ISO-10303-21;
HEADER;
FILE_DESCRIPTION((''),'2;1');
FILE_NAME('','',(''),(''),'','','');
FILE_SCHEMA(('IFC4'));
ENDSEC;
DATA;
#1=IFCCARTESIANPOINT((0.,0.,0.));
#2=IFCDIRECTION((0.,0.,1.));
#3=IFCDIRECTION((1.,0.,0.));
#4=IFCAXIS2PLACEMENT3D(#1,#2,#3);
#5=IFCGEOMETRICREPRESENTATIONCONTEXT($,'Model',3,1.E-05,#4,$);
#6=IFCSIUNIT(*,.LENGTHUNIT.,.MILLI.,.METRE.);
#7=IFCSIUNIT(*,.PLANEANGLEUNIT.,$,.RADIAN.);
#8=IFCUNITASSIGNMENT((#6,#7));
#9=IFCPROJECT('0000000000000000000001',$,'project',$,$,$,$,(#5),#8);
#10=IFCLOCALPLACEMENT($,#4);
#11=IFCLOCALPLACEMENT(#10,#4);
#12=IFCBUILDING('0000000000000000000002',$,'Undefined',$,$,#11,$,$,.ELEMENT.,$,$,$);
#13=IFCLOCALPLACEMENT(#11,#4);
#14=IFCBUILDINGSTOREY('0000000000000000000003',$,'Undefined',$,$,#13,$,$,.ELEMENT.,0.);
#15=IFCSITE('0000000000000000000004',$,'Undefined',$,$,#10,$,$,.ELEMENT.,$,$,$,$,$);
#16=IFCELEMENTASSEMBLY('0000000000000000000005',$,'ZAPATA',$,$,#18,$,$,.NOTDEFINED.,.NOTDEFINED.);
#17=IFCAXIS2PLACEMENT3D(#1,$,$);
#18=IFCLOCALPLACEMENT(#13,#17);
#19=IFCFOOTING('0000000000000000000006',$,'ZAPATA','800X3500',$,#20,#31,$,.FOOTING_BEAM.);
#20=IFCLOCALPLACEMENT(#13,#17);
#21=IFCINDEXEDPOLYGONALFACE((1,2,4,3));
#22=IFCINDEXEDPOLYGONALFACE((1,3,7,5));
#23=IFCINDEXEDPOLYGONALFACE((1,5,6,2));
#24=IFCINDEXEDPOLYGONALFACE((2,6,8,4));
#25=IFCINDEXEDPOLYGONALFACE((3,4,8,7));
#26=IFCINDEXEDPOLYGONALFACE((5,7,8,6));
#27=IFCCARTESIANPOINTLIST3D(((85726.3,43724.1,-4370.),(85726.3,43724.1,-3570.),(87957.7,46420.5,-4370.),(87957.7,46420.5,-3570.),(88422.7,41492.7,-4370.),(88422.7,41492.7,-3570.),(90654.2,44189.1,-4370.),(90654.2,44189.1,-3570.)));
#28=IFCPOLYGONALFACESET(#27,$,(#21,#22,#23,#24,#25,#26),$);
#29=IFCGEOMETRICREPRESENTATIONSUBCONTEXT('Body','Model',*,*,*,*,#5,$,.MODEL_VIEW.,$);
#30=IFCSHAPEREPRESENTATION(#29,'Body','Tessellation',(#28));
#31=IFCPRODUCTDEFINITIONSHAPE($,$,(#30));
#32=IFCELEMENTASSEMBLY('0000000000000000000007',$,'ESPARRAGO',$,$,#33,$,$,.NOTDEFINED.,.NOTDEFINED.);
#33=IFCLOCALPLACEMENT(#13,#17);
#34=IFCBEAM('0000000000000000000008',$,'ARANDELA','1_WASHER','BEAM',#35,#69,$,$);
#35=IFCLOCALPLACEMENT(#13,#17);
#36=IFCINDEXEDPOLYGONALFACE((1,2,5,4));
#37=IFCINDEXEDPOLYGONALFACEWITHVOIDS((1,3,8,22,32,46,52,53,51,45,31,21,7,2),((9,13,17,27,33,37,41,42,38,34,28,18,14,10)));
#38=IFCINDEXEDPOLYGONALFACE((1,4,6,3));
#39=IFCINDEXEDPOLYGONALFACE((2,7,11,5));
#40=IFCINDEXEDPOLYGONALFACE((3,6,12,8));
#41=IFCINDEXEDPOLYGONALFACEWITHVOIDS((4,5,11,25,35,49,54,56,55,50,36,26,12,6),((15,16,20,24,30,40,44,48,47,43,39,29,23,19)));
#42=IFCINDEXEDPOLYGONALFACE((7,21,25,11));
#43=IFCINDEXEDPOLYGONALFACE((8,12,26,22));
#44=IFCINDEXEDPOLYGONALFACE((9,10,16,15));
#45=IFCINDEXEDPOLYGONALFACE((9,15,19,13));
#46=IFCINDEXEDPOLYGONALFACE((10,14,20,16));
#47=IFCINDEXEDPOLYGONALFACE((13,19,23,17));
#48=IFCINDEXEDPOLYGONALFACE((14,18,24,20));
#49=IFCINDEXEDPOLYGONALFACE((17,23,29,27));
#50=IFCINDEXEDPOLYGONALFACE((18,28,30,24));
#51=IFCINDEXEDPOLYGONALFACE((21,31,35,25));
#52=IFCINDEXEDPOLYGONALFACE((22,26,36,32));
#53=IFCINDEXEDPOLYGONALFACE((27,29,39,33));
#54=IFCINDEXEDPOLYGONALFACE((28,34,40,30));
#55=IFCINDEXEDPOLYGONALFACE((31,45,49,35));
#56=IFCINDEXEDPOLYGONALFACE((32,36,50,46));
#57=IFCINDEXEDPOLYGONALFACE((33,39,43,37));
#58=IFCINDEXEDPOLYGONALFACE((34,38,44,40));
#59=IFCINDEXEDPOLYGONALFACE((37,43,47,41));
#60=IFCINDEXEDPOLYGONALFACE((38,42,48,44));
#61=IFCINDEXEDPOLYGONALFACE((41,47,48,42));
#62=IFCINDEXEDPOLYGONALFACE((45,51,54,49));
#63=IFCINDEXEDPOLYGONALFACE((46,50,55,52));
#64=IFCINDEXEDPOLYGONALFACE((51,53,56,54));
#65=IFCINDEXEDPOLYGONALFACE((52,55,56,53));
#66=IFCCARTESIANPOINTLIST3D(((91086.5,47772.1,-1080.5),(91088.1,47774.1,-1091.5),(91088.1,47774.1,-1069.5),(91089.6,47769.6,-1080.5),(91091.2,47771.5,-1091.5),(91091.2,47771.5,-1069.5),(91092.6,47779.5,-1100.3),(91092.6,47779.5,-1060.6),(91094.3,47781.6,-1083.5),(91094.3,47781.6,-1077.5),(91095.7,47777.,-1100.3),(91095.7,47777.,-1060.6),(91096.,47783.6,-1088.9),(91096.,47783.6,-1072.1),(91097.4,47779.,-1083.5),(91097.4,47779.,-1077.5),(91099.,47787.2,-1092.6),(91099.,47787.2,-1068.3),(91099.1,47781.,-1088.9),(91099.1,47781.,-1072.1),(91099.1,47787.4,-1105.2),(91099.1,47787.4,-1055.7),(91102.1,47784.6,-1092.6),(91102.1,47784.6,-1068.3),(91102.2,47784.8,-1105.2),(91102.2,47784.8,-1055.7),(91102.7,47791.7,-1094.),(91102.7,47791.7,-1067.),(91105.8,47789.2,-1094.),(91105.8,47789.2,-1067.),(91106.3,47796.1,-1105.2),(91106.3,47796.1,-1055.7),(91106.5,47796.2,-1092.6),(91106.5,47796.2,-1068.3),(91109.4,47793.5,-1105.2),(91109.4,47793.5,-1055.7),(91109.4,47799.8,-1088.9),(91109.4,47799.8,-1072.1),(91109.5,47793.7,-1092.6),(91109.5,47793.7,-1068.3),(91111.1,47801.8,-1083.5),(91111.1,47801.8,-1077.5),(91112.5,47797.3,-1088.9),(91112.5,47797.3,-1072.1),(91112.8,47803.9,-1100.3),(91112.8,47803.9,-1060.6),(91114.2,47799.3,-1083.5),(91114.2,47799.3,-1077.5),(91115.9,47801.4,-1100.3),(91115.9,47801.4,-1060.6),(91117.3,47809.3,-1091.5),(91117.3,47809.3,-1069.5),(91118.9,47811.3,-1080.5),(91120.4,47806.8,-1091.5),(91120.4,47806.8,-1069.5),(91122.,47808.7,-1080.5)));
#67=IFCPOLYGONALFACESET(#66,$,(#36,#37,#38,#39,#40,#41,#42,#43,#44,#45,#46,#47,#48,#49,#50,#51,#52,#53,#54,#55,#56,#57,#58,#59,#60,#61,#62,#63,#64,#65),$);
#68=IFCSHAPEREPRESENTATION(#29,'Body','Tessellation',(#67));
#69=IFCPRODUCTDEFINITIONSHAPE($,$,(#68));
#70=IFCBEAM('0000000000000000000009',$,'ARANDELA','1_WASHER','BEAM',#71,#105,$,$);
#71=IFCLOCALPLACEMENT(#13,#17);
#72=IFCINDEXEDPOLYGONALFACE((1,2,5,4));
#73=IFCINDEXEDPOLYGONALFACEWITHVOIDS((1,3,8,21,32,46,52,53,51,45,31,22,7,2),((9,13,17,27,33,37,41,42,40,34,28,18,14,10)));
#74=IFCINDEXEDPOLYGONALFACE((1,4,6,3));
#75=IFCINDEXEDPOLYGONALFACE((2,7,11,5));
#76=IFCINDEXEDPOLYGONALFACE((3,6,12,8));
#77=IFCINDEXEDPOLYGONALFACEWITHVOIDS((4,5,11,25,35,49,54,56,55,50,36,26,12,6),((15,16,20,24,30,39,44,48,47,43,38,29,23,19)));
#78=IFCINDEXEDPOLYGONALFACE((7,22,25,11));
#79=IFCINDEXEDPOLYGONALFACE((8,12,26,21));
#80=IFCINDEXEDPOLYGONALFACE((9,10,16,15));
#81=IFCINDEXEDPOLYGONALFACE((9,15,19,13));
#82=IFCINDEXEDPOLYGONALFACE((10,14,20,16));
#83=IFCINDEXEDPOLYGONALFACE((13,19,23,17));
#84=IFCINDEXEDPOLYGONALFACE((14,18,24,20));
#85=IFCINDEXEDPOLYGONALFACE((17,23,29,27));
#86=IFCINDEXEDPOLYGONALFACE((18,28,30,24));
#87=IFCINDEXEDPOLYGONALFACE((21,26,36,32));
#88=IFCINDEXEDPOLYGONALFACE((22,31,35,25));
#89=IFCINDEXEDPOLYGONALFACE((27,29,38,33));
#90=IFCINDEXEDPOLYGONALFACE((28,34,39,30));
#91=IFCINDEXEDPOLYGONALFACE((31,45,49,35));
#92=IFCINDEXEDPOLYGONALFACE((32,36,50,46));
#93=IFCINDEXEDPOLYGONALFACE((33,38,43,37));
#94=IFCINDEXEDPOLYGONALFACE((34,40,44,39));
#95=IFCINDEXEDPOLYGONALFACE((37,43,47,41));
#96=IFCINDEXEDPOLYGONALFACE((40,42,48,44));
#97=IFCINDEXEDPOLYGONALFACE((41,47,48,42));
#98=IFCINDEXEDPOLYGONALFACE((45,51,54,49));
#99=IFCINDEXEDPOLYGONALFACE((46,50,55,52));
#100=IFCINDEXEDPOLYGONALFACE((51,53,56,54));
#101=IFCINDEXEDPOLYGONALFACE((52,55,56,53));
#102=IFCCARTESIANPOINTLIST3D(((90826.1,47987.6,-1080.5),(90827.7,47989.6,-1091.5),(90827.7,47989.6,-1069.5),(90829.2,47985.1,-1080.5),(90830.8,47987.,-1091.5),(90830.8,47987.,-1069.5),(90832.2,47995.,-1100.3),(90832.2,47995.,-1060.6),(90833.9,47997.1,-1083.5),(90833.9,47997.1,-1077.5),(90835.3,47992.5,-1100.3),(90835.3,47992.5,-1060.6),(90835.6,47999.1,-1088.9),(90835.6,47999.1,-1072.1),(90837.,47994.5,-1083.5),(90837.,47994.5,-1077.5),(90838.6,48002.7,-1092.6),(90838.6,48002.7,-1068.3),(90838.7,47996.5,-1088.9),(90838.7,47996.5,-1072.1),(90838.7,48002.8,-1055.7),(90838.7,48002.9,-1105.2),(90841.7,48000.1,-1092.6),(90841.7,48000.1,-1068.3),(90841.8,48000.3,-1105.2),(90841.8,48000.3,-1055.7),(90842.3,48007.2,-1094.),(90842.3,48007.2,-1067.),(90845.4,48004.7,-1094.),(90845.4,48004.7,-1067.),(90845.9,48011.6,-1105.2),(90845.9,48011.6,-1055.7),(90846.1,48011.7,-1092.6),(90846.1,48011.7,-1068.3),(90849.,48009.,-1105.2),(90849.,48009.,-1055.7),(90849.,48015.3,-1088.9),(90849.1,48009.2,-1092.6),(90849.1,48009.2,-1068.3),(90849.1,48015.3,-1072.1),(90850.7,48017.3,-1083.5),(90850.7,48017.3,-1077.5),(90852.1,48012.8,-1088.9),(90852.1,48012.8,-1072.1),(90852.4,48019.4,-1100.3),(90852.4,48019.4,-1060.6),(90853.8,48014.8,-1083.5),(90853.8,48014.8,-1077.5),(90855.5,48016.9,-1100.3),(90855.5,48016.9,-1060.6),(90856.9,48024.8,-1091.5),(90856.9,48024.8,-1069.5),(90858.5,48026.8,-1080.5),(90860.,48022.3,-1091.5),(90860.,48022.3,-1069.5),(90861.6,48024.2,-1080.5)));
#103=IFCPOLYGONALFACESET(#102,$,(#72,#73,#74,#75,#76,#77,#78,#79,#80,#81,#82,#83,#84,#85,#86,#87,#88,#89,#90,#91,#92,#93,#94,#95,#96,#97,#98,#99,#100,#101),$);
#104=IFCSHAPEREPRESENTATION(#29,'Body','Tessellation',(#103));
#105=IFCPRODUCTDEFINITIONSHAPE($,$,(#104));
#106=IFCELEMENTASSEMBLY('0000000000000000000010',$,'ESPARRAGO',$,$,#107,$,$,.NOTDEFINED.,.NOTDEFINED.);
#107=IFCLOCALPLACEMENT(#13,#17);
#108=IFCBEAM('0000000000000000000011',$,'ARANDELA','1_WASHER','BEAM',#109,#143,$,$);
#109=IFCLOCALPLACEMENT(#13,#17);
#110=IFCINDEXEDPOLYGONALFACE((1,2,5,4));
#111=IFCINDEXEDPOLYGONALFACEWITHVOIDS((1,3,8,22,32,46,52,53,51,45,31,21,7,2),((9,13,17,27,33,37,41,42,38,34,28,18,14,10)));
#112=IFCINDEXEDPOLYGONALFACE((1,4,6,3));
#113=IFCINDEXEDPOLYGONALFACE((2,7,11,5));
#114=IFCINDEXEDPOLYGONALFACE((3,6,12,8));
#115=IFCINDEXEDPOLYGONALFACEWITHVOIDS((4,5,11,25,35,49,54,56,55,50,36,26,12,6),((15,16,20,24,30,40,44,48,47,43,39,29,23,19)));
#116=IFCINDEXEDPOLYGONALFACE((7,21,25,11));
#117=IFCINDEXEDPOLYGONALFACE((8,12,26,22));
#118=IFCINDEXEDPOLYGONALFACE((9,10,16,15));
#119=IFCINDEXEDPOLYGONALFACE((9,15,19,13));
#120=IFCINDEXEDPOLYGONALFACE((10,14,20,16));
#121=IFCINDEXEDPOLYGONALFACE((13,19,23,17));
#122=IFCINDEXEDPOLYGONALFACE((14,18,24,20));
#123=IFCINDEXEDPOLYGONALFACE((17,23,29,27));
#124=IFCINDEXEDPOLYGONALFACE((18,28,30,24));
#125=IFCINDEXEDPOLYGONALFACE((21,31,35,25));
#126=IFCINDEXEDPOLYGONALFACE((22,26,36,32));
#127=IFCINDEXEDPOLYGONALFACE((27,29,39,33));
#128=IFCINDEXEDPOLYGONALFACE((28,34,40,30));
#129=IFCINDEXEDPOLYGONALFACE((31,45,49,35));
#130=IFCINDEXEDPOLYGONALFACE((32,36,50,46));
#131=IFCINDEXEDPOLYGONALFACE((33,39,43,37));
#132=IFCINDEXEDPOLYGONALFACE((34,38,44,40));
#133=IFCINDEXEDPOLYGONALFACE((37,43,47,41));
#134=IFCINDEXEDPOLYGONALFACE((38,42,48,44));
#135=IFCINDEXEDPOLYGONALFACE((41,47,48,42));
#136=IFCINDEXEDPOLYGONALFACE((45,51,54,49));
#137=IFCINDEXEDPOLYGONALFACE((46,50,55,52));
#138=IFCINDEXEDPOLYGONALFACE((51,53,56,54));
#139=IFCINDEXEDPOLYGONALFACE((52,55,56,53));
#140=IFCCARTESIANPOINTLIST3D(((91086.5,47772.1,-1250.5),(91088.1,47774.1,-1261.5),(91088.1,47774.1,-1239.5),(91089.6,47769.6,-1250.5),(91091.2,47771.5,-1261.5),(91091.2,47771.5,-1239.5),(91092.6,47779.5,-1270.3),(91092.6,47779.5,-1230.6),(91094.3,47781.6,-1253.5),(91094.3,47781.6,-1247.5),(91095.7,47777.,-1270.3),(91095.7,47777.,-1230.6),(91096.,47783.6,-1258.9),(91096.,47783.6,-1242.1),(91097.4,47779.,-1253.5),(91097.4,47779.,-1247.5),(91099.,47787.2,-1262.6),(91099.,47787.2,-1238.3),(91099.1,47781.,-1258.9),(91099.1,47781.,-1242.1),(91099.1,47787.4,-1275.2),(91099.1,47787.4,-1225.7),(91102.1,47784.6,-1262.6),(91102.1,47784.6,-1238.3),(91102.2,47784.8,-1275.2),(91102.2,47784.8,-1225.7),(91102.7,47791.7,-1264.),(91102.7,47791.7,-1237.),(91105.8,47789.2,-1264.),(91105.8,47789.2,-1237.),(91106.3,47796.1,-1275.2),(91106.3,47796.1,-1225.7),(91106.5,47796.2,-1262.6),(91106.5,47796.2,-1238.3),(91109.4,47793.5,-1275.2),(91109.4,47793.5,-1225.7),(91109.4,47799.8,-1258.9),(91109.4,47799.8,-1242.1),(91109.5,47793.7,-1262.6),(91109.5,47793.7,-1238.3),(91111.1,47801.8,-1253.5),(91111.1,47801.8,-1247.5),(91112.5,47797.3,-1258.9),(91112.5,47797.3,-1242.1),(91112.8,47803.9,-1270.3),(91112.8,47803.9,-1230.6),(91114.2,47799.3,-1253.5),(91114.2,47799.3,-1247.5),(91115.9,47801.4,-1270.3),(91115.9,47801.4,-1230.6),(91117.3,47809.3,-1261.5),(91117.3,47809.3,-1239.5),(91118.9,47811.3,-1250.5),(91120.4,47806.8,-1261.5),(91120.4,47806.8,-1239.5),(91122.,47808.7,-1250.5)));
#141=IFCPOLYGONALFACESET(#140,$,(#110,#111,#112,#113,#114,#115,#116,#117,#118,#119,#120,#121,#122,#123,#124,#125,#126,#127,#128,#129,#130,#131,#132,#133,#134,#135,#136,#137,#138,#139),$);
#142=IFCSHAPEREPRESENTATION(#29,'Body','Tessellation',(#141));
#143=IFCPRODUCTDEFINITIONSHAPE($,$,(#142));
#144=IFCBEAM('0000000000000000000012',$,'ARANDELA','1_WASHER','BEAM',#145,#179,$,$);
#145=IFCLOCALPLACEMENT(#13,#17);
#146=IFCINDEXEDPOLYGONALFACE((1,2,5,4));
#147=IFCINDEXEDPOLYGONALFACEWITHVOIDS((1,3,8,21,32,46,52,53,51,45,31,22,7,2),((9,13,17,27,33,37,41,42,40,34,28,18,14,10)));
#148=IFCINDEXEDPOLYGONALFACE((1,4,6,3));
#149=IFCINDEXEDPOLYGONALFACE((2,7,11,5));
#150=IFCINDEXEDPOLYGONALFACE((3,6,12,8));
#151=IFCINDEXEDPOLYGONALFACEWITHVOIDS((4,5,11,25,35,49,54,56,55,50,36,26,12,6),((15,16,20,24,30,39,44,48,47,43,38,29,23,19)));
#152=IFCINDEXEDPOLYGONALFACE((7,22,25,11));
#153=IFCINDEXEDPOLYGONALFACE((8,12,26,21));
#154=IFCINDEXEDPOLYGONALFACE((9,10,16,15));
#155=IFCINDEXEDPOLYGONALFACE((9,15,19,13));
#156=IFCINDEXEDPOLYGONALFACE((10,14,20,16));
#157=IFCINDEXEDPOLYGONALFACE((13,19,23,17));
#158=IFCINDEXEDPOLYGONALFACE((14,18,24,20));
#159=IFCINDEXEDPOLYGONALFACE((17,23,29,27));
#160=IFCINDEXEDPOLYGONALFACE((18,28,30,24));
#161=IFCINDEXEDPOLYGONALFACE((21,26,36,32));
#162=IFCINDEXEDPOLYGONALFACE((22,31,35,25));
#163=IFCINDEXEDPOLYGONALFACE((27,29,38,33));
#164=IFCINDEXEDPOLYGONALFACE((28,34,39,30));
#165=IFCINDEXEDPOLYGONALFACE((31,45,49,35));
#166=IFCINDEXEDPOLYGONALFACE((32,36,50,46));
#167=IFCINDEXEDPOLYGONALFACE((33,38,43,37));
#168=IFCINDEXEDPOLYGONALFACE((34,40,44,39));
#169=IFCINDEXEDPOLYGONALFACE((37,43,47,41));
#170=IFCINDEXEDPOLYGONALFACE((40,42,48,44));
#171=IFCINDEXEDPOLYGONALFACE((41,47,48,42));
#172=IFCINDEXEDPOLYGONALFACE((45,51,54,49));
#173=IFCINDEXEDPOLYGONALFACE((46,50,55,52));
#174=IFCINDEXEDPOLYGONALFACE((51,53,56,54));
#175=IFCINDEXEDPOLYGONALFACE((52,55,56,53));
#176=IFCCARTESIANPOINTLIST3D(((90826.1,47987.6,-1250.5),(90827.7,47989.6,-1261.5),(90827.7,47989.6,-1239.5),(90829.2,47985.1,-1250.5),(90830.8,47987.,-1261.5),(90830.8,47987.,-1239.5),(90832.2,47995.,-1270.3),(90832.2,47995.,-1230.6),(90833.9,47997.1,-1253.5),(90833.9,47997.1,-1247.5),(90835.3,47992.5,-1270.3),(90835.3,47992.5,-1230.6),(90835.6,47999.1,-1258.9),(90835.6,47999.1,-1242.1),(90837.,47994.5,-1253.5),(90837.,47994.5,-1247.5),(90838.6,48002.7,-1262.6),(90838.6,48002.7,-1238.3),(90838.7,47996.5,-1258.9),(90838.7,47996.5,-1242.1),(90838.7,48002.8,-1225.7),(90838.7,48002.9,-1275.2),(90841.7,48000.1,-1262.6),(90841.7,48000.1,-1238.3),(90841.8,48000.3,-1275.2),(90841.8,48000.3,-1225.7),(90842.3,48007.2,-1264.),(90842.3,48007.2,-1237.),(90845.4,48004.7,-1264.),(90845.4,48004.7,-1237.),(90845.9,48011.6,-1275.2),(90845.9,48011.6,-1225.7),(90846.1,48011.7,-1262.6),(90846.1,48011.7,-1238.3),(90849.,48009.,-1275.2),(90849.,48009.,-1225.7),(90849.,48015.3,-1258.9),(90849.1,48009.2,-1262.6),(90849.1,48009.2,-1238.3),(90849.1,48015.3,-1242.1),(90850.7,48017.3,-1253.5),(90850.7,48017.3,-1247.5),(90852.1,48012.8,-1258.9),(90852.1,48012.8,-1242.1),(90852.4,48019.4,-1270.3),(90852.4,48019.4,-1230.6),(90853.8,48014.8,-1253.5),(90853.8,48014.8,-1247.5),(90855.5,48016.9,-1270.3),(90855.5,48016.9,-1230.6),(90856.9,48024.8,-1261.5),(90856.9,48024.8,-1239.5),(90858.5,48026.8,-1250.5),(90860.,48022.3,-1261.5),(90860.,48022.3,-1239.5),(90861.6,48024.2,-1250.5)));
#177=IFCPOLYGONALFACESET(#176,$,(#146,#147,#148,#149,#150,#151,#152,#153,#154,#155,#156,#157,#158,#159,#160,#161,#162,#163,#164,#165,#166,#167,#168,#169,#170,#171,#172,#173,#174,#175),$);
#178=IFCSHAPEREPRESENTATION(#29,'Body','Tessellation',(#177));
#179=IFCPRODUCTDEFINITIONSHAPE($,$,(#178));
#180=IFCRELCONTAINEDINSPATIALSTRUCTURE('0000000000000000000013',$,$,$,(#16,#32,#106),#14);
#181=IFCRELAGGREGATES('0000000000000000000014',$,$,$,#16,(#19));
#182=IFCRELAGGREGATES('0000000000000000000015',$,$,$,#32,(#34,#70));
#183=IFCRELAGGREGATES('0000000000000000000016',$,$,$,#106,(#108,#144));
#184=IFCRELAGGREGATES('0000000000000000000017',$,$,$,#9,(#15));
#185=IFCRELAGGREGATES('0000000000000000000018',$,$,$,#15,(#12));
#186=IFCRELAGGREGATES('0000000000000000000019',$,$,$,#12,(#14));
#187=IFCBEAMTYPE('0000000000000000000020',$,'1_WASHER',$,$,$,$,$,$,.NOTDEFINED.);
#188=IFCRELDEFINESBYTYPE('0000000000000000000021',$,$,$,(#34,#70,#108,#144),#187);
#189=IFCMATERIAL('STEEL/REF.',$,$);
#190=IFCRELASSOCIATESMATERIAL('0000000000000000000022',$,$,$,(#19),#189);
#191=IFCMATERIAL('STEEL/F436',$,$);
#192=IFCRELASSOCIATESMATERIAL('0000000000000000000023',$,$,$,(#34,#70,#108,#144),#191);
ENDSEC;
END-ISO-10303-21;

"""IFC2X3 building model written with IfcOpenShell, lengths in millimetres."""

from ifc_helpers import new_model, si_unit, frame, origin_with_axes, origin_2d_with_axis, place, context, subcontext, project, spatial, polyline, rectangle, outline, extrude, material, type_object, element, aggregate, save


model = new_model("IFC2X3")

# Units and contexts
model_context = context("Model", 3, precision=1e-05, world=origin_with_axes())
body_context = subcontext(model_context, "Body", "Model", "MODEL_VIEW")
ifc_project = project(units=[si_unit("LENGTHUNIT", "METRE", prefix="MILLI"), si_unit("PLANEANGLEUNIT", "RADIAN")], contexts=[model_context])

# Site, building, storey
site_placement = place(None, origin_with_axes())
site = spatial("IfcSite", under=ifc_project, at=site_placement, Name="Undefined", CompositionType="ELEMENT")
building_placement = place(site_placement, origin_with_axes())
building = spatial("IfcBuilding", under=site, at=building_placement, Name="Undefined", CompositionType="ELEMENT")
storey_placement = place(building_placement, origin_with_axes())
storey = spatial("IfcBuildingStorey", under=building, at=storey_placement, Name="Undefined", CompositionType="ELEMENT", Elevation=0.0)

# Element assembly, footing
assembly_1_placement = place(storey_placement, origin_with_axes())
assembly_1 = element("IfcElementAssembly", 1, at=assembly_1_placement, inside=storey, Name="ZAPATA", AssemblyPlace="NOTDEFINED", PredefinedType="NOTDEFINED")
ifc_material_1 = material(Name="STEEL/REF.")
footing_placement = place(assembly_1_placement, frame((86842.0, 45072.3, -3970.0), z_axis=(0.0, 0.0, 1.0), x_axis=(0.770402, -0.637558, 0.0)))
footing = element("IfcFooting", 2, at=footing_placement, material=ifc_material_1, Name="ZAPATA", Description="800X3500", PredefinedType="FOOTING_BEAM", context=body_context, shape_type="SweptSolid", body=[
    extrude(rectangle(XDim=3500.0, YDim=800.0, at=origin_2d_with_axis()), frame((3500.0, 0.0, 0.0), z_axis=(-1.0, 0.0, 0.0), x_axis=(0.0, -1.0, 0.0)), (0.0, 0.0, 1.0), 3500.0),
])
aggregate(assembly_1, [footing])

# Element assemblies, beams
assembly_2_placement = place(storey_placement, origin_with_axes())
assembly_2 = element("IfcElementAssembly", 3, at=assembly_2_placement, inside=storey, Name="ESPARRAGO", AssemblyPlace="NOTDEFINED", PredefinedType="NOTDEFINED")
ifc_material_2 = material(Name="STEEL/F436")
beam_type_1 = type_object("IfcBeamType", Name="1_WASHER", PredefinedType="NOTDEFINED")
beam_1_placement = place(assembly_2_placement, frame((91102.7, 47791.7, -1080.5), z_axis=(0.000066, -0.000055, 1.0), x_axis=(0.770401, -0.63756, -0.000086)))
beam_1 = element("IfcBeam", 4, at=beam_1_placement, type_object=beam_type_1, material=ifc_material_2, Name="ARANDELA", Description="1_WASHER", ObjectType="BEAM", context=body_context, shape_type="SweptSolid", body=[
    extrude(outline(polyline([(-15.8, -19.9), (-22.9, -11.0), (-25.4, 0.0), (-22.9, 11.0), (-15.8, 19.9), (-5.7, 24.8), (5.7, 24.8), (15.8, 19.9), (22.9, 11.0), (25.4, 0.0), (22.9, -11.0), (15.8, -19.9), (5.7, -24.8), (-5.7, -24.8), (-15.8, -19.9)]), holes=[polyline([(-5.9, 12.2), (-10.5, 8.4), (-13.2, 3.0), (-13.2, -3.0), (-10.5, -8.4), (-5.9, -12.2), (0.0, -13.5), (5.9, -12.2), (10.5, -8.4), (13.2, -3.0), (13.2, 3.0), (10.5, 8.4), (5.9, 12.2), (0.0, 13.5), (-5.9, 12.2)])]), frame((4.0, 0.0, 0.0), z_axis=(-1.0, 0.0, 0.0), x_axis=(0.0, -1.0, 0.0)), (0.0, 0.0, 1.0), 4.0),
])
beam_2_placement = place(assembly_2_placement, frame((90842.3, 48007.2, -1080.5), z_axis=(0.000066, -0.000055, 1.0), x_axis=(0.770401, -0.63756, -0.000086)))
beam_2 = element("IfcBeam", 5, at=beam_2_placement, type_object=beam_type_1, material=ifc_material_2, Name="ARANDELA", Description="1_WASHER", ObjectType="BEAM", context=body_context, shape_type="SweptSolid", body=[
    extrude(outline(polyline([(-15.8, -19.9), (-22.9, -11.0), (-25.4, 0.0), (-22.9, 11.0), (-15.8, 19.9), (-5.7, 24.8), (5.7, 24.8), (15.8, 19.9), (22.9, 11.0), (25.4, 0.0), (22.9, -11.0), (15.8, -19.9), (5.7, -24.8), (-5.7, -24.8), (-15.8, -19.9)]), holes=[polyline([(-5.9, 12.2), (-10.5, 8.4), (-13.2, 3.0), (-13.2, -3.0), (-10.5, -8.4), (-5.9, -12.2), (0.0, -13.5), (5.9, -12.2), (10.5, -8.4), (13.2, -3.0), (13.2, 3.0), (10.5, 8.4), (5.9, 12.2), (0.0, 13.5), (-5.9, 12.2)])]), frame((4.0, 0.0, 0.0), z_axis=(-1.0, 0.0, 0.0), x_axis=(0.0, -1.0, 0.0)), (0.0, 0.0, 1.0), 4.0),
])
aggregate(assembly_2, [beam_1, beam_2])
assembly_3_placement = place(storey_placement, origin_with_axes())
assembly_3 = element("IfcElementAssembly", 6, at=assembly_3_placement, inside=storey, Name="ESPARRAGO", AssemblyPlace="NOTDEFINED", PredefinedType="NOTDEFINED")
beam_3_placement = place(assembly_3_placement, frame((91102.7, 47791.7, -1250.5), z_axis=(0.000066, -0.000055, 1.0), x_axis=(0.770401, -0.63756, -0.000086)))
beam_3 = element("IfcBeam", 7, at=beam_3_placement, type_object=beam_type_1, material=ifc_material_2, Name="ARANDELA", Description="1_WASHER", ObjectType="BEAM", context=body_context, shape_type="SweptSolid", body=[
    extrude(outline(polyline([(-15.8, -19.9), (-22.9, -11.0), (-25.4, 0.0), (-22.9, 11.0), (-15.8, 19.9), (-5.7, 24.8), (5.7, 24.8), (15.8, 19.9), (22.9, 11.0), (25.4, 0.0), (22.9, -11.0), (15.8, -19.9), (5.7, -24.8), (-5.7, -24.8), (-15.8, -19.9)]), holes=[polyline([(-5.9, 12.2), (-10.5, 8.4), (-13.2, 3.0), (-13.2, -3.0), (-10.5, -8.4), (-5.9, -12.2), (0.0, -13.5), (5.9, -12.2), (10.5, -8.4), (13.2, -3.0), (13.2, 3.0), (10.5, 8.4), (5.9, 12.2), (0.0, 13.5), (-5.9, 12.2)])]), frame((4.0, 0.0, 0.0), z_axis=(-1.0, 0.0, 0.0), x_axis=(0.0, -1.0, 0.0)), (0.0, 0.0, 1.0), 4.0),
])
beam_4_placement = place(assembly_3_placement, frame((90842.3, 48007.2, -1250.5), z_axis=(0.000066, -0.000055, 1.0), x_axis=(0.770401, -0.63756, -0.000086)))
beam_4 = element("IfcBeam", 8, at=beam_4_placement, type_object=beam_type_1, material=ifc_material_2, Name="ARANDELA", Description="1_WASHER", ObjectType="BEAM", context=body_context, shape_type="SweptSolid", body=[
    extrude(outline(polyline([(-15.8, -19.9), (-22.9, -11.0), (-25.4, 0.0), (-22.9, 11.0), (-15.8, 19.9), (-5.7, 24.8), (5.7, 24.8), (15.8, 19.9), (22.9, 11.0), (25.4, 0.0), (22.9, -11.0), (15.8, -19.9), (5.7, -24.8), (-5.7, -24.8), (-15.8, -19.9)]), holes=[polyline([(-5.9, 12.2), (-10.5, 8.4), (-13.2, 3.0), (-13.2, -3.0), (-10.5, -8.4), (-5.9, -12.2), (0.0, -13.5), (5.9, -12.2), (10.5, -8.4), (13.2, -3.0), (13.2, 3.0), (10.5, 8.4), (5.9, 12.2), (0.0, 13.5), (-5.9, 12.2)])]), frame((4.0, 0.0, 0.0), z_axis=(-1.0, 0.0, 0.0), x_axis=(0.0, -1.0, 0.0)), (0.0, 0.0, 1.0), 4.0),
])
aggregate(assembly_3, [beam_3, beam_4])

save(model, "model.ifc")
